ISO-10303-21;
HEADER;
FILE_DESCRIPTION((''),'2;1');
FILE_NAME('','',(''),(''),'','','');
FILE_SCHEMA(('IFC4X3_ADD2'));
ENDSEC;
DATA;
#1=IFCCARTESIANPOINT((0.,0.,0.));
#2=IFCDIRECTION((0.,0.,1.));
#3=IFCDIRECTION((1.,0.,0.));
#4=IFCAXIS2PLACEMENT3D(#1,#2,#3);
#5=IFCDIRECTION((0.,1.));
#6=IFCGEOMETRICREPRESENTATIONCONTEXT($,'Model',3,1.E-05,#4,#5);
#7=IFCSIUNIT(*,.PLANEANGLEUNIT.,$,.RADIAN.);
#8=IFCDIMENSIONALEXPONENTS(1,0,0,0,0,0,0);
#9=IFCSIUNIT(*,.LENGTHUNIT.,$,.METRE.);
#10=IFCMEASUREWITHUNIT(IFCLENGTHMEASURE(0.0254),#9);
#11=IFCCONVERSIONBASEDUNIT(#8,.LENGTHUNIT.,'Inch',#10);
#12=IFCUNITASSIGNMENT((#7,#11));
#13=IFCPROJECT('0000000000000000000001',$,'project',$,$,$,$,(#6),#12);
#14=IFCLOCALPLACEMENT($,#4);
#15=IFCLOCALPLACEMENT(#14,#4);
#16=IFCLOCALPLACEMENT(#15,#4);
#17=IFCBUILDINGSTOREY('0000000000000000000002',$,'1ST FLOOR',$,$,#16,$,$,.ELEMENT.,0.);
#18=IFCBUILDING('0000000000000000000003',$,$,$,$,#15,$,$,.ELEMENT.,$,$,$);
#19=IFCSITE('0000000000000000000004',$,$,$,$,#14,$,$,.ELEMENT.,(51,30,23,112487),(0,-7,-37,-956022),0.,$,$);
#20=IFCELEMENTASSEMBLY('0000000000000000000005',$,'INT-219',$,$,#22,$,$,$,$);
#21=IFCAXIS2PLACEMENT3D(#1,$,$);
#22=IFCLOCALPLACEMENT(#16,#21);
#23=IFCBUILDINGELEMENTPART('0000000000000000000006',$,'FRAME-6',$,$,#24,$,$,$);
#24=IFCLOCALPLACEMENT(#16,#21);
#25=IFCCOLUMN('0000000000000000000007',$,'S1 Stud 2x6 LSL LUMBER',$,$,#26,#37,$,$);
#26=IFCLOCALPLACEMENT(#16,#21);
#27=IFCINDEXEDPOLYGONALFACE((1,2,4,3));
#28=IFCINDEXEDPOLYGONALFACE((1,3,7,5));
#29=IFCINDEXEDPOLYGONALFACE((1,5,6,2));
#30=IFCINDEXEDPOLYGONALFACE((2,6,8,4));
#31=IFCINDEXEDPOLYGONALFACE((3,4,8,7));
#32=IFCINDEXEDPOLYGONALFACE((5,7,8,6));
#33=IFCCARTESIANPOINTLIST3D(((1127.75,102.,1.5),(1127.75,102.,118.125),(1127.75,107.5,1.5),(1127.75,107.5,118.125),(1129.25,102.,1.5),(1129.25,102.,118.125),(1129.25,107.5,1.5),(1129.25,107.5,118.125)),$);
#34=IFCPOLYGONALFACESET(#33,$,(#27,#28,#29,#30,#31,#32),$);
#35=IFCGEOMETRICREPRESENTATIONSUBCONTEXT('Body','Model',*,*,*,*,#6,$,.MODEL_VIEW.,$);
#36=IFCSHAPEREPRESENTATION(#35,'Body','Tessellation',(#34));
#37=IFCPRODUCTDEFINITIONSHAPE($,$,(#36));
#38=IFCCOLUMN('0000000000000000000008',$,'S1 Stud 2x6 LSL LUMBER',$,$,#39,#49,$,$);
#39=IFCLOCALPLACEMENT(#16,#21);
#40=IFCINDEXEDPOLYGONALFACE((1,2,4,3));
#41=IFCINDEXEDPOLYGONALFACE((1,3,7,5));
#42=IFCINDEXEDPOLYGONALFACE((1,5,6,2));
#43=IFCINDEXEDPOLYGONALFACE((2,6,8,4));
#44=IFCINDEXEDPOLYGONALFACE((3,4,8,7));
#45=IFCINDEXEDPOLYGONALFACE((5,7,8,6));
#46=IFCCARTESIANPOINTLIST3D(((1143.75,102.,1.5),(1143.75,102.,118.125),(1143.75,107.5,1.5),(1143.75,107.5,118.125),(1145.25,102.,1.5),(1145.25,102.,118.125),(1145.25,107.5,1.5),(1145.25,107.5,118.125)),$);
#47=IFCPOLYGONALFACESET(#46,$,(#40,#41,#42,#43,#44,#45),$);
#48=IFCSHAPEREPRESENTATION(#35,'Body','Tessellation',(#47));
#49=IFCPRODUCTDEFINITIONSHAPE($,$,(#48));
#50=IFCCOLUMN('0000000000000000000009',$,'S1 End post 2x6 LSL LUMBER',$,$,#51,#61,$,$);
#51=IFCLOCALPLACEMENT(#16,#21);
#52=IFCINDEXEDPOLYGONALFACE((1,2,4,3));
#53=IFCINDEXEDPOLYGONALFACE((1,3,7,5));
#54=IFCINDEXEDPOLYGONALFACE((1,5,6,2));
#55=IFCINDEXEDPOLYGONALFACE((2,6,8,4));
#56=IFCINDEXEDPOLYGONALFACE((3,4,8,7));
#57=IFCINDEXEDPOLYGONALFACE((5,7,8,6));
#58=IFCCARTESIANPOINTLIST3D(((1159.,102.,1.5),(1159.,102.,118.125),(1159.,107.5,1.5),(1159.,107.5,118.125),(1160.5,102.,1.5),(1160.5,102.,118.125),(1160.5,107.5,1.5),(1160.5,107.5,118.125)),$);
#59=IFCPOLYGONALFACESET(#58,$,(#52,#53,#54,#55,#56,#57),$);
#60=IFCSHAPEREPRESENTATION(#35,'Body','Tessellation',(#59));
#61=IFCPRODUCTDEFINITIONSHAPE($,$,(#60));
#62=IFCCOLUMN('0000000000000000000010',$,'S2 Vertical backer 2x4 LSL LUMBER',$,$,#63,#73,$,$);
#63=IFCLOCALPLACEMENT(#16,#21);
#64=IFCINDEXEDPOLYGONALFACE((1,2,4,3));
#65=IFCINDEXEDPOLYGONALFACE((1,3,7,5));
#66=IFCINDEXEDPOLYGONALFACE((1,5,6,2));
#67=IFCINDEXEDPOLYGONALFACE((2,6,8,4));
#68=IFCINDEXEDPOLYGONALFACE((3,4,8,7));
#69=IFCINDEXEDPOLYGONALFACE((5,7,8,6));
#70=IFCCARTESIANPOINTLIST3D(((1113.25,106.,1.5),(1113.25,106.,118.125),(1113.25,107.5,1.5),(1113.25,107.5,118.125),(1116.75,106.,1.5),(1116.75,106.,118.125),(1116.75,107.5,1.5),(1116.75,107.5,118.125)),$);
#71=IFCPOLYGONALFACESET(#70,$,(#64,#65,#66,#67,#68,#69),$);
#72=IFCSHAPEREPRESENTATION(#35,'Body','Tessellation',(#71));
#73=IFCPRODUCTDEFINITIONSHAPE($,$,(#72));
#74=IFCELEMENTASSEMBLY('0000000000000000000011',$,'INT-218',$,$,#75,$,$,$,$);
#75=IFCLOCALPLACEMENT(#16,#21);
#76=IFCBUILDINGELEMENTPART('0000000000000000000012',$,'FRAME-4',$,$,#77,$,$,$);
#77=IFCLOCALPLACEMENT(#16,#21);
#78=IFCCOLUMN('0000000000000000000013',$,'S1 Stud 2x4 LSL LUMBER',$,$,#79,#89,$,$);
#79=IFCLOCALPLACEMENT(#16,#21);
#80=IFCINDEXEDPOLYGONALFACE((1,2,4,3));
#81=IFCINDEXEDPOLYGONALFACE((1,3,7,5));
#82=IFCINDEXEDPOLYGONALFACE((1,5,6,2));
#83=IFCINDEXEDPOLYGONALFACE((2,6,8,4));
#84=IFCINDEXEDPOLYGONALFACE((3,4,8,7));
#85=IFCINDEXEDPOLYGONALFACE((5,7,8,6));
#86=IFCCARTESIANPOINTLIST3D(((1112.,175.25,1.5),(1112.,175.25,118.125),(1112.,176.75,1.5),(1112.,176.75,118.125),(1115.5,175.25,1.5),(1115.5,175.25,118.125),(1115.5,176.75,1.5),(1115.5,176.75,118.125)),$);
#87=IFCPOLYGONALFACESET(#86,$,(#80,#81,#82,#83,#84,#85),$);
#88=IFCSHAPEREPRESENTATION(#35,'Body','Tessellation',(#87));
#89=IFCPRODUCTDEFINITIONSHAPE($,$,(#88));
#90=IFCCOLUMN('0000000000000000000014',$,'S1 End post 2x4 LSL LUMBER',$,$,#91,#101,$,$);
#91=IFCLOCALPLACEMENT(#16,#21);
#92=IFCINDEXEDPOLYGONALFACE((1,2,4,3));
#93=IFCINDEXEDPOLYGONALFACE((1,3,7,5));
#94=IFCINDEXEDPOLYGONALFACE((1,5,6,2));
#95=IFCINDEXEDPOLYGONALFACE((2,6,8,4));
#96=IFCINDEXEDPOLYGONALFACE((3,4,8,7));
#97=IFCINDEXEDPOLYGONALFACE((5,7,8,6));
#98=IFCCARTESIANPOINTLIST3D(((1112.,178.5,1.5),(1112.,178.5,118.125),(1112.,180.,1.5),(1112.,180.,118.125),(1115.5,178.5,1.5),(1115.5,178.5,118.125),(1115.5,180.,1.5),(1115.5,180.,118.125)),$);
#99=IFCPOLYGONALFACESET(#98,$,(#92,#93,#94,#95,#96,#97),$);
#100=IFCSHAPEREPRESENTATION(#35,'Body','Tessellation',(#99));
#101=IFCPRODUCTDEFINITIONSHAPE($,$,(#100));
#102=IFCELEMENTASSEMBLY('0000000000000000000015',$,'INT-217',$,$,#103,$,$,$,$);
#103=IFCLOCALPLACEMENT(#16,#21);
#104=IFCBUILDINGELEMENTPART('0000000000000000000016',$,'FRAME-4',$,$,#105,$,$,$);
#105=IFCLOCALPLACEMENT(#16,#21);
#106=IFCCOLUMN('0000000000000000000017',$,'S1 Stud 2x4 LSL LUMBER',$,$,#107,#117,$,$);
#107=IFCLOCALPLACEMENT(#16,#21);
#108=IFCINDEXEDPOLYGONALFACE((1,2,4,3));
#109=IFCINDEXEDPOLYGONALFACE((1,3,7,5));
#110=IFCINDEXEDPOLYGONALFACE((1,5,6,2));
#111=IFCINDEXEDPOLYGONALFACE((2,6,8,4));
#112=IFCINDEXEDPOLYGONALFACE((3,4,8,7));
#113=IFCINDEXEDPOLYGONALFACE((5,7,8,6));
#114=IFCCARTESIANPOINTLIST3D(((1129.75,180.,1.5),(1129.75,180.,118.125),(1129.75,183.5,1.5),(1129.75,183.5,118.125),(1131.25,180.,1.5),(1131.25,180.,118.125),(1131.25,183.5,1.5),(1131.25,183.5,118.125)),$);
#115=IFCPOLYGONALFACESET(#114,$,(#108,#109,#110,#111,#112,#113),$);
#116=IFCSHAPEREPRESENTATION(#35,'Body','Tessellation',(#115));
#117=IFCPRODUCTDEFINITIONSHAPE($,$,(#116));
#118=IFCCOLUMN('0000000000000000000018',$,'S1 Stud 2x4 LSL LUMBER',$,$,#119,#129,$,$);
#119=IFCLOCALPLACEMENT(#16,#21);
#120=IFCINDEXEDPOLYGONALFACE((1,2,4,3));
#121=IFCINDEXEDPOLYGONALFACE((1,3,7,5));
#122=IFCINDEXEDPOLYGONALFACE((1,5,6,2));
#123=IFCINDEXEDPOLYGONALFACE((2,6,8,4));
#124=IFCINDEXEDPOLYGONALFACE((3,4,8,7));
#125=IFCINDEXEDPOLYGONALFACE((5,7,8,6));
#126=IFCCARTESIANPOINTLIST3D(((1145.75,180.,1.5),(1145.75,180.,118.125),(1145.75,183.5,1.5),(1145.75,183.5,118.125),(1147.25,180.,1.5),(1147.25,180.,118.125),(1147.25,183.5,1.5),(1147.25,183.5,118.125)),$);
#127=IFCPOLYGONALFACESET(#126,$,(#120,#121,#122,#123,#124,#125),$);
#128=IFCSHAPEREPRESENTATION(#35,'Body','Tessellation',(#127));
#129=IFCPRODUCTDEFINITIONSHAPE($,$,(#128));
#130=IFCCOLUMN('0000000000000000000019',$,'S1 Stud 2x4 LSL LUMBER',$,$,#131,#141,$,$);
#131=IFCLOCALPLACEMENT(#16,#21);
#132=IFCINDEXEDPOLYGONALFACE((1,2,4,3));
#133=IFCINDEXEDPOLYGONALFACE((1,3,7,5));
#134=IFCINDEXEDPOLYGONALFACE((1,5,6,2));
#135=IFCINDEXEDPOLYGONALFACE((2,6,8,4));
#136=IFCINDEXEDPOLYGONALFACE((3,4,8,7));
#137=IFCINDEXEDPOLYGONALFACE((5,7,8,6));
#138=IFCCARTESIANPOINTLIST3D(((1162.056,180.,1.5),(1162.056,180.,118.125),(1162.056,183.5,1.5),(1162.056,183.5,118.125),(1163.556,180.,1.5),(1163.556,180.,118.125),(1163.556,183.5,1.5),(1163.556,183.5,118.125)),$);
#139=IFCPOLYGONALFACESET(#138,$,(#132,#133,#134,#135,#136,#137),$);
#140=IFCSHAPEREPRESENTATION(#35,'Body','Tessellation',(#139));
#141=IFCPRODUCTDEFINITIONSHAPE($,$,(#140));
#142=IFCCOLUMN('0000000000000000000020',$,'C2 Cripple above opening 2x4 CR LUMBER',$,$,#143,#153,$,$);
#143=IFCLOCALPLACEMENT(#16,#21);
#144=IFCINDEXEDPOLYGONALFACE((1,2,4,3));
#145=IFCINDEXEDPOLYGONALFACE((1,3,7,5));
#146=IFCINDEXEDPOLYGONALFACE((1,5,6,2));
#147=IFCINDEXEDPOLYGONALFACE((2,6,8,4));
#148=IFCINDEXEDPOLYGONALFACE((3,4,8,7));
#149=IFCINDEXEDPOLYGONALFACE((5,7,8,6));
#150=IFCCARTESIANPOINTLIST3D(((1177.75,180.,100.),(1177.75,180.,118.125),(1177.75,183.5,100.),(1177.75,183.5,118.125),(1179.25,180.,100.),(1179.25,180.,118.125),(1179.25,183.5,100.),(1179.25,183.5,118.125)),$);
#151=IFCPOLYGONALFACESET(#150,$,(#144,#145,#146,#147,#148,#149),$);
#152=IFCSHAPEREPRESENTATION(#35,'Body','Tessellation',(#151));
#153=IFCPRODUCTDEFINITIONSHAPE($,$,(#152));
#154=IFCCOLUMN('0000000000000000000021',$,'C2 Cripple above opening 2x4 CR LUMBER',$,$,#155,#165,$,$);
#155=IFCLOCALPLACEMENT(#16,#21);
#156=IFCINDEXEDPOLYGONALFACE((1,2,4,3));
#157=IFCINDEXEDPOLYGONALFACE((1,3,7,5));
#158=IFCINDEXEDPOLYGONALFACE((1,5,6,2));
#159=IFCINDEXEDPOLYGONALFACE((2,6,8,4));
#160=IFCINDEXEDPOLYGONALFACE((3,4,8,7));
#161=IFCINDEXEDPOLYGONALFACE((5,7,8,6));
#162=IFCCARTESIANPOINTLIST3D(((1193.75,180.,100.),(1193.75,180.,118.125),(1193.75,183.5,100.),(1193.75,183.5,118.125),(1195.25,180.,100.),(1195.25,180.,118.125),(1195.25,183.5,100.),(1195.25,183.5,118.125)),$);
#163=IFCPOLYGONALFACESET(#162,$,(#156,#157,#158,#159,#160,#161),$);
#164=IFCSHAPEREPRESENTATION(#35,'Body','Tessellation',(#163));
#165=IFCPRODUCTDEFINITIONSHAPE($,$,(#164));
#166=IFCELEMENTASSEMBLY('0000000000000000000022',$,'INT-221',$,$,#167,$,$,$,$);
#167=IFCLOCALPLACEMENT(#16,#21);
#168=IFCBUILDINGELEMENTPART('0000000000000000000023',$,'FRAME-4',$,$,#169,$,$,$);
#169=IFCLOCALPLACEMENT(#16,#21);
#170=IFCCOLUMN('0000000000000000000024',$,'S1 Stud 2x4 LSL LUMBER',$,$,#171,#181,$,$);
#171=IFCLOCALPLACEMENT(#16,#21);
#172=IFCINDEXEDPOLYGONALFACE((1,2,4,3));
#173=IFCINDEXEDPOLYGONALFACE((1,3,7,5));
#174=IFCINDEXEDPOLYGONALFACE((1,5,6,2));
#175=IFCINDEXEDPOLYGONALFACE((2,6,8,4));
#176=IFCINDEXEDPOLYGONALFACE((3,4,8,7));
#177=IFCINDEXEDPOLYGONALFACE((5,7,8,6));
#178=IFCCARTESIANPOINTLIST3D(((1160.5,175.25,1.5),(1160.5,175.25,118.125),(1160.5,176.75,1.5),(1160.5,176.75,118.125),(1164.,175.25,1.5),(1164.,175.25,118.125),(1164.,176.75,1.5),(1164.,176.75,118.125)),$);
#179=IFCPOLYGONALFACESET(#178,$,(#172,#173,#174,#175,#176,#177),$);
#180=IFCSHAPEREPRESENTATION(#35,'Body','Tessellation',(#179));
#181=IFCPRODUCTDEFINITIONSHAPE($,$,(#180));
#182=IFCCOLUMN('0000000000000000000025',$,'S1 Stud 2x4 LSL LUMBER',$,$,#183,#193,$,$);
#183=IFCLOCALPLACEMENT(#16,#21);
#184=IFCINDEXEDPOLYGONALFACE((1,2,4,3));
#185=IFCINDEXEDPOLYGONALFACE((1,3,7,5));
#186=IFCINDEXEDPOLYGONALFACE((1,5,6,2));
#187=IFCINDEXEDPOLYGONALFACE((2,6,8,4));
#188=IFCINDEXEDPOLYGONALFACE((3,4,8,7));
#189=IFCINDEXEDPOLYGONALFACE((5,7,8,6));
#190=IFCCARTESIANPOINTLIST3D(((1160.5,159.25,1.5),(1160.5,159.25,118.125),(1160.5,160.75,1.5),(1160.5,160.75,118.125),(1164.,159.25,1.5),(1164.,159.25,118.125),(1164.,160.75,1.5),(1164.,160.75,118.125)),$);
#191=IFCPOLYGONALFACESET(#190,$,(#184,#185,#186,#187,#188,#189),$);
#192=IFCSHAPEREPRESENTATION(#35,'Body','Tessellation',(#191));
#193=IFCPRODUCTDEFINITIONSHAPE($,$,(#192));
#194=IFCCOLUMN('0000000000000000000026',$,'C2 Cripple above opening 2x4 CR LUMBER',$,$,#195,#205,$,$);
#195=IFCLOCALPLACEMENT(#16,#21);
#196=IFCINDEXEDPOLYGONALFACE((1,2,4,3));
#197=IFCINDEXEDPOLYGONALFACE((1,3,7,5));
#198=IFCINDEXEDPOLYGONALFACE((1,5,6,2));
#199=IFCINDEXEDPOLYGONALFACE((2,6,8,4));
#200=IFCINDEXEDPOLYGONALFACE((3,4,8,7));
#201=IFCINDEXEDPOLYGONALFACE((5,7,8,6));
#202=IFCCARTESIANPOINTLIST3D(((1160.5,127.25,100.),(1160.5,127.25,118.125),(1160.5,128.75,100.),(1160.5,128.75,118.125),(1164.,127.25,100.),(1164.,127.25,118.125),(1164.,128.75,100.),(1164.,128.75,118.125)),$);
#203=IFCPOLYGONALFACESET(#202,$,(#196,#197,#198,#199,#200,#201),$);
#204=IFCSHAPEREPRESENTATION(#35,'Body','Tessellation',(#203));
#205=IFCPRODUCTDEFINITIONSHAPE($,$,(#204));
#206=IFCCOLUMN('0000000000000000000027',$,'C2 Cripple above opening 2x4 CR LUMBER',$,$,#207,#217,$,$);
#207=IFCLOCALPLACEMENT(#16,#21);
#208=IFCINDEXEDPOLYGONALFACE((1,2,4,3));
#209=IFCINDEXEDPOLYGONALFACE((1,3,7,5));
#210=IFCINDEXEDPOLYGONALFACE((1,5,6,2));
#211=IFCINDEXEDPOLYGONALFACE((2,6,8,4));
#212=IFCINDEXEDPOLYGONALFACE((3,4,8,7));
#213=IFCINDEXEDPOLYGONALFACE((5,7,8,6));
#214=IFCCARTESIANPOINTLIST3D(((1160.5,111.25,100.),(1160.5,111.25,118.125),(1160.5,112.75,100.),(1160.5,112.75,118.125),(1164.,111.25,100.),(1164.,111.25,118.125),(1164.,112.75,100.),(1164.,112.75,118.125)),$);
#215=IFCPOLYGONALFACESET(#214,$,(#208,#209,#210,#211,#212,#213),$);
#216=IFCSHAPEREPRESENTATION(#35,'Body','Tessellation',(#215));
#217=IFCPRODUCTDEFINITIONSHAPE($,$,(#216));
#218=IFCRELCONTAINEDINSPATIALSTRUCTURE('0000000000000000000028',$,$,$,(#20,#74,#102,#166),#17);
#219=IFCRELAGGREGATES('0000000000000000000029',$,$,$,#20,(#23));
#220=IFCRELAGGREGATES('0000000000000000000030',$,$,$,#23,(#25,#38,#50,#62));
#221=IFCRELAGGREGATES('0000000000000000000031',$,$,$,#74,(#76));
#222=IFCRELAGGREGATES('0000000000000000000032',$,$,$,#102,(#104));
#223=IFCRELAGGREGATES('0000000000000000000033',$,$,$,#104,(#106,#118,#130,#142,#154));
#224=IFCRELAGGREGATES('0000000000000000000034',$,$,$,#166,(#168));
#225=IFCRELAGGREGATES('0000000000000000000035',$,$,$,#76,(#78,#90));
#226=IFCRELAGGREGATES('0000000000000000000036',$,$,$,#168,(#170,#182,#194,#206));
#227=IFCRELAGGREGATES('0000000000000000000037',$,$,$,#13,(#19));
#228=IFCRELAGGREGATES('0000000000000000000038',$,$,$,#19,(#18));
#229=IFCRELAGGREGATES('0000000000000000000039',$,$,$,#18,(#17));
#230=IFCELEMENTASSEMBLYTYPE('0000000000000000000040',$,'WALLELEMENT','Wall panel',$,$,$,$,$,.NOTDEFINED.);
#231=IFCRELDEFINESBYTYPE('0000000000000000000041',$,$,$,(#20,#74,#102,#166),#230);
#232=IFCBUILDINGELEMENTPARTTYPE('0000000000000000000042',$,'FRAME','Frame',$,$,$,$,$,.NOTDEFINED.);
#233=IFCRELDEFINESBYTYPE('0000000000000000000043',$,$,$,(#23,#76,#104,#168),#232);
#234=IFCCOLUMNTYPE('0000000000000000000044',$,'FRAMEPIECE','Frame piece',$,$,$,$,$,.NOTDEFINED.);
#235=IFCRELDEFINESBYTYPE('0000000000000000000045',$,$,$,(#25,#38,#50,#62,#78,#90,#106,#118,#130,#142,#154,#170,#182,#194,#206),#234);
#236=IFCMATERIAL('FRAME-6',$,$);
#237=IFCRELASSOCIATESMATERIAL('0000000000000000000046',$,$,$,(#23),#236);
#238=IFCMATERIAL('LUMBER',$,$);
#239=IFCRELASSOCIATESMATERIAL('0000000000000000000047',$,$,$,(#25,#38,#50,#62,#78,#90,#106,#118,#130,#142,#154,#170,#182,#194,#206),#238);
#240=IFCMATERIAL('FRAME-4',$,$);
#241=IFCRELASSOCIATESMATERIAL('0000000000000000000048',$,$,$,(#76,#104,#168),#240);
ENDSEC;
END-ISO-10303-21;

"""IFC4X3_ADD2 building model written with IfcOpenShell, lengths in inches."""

from ifc_helpers import new_model, entity, si_unit, converted_unit, direction, frame, origin_with_axes, origin_2d_with_axis, place, context, subcontext, project, spatial, rectangle, extrude, material, type_object, element, aggregate, save


model = new_model("IFC4X3_ADD2")

# Units and contexts
model_context = context("Model", 3, precision=1e-05, world=origin_with_axes(), true_north=direction((0.0, 1.0)))
body_context = subcontext(model_context, "Body", "Model", "MODEL_VIEW")
ifc_project = project(units=[si_unit("PLANEANGLEUNIT", "RADIAN"), converted_unit("LENGTHUNIT", "Inch", entity("IfcLengthMeasure", 0.0254), si_unit("LENGTHUNIT", "METRE"), dimensions=[1, 0, 0, 0, 0, 0, 0])], contexts=[model_context])

# Site, building, storey
site_placement = place(None, origin_with_axes())
site = spatial("IfcSite", under=ifc_project, at=site_placement, CompositionType="ELEMENT", RefLatitude=(51, 30, 23, 112487), RefLongitude=(0, -7, -37, -956022), RefElevation=0.0)
building_placement = place(site_placement, origin_with_axes())
building = spatial("IfcBuilding", under=site, at=building_placement, CompositionType="ELEMENT")
storey_placement = place(building_placement, origin_with_axes())
storey = spatial("IfcBuildingStorey", under=building, at=storey_placement, Name="1ST FLOOR", CompositionType="ELEMENT", Elevation=0.0)

# Element assemblies, building element parts, columns
element_assembly_type = type_object("IfcElementAssemblyType", Name="WALLELEMENT", Description="Wall panel", PredefinedType="NOTDEFINED")
assembly_1_placement = place(storey_placement, origin_with_axes())
assembly_1 = element("IfcElementAssembly", 1, at=assembly_1_placement, inside=storey, type_object=element_assembly_type, Name="INT-219")
ifc_material_1 = material(Name="FRAME-6")
building_element_part_type = type_object("IfcBuildingElementPartType", Name="FRAME", Description="Frame", PredefinedType="NOTDEFINED")
building_element_part_1_placement = place(storey_placement, origin_with_axes())
building_element_part_1 = element("IfcBuildingElementPart", 2, at=building_element_part_1_placement, type_object=building_element_part_type, material=ifc_material_1, Name="FRAME-6")
aggregate(assembly_1, [building_element_part_1])
ifc_material_2 = material(Name="LUMBER")
column_type = type_object("IfcColumnType", Name="FRAMEPIECE", Description="Frame piece", PredefinedType="NOTDEFINED")
column_1_placement = place(storey_placement, frame((1128.5, 104.75, 118.125), z_axis=(0.0, 0.0, -1.0), x_axis=(-1.0, 0.0, 0.0)))
column_1 = element("IfcColumn", 3, at=column_1_placement, type_object=column_type, material=ifc_material_2, Name="S1 Stud 2x6 LSL LUMBER", context=body_context, shape_type="SweptSolid", body=[
    extrude(rectangle(XDim=1.5, YDim=5.5, at=origin_2d_with_axis()), origin_with_axes(), (0.0, 0.0, 1.0), 116.625),
])
column_2_placement = place(storey_placement, frame((1144.5, 104.75, 118.125), z_axis=(0.0, 0.0, -1.0), x_axis=(-1.0, 0.0, 0.0)))
column_2 = element("IfcColumn", 4, at=column_2_placement, type_object=column_type, material=ifc_material_2, Name="S1 Stud 2x6 LSL LUMBER", context=body_context, shape_type="SweptSolid", body=[
    extrude(rectangle(XDim=1.5, YDim=5.5, at=origin_2d_with_axis()), origin_with_axes(), (0.0, 0.0, 1.0), 116.625),
])
column_3_placement = place(storey_placement, frame((1159.75, 104.75, 118.125), z_axis=(0.0, 0.0, -1.0), x_axis=(-1.0, 0.0, 0.0)))
column_3 = element("IfcColumn", 5, at=column_3_placement, type_object=column_type, material=ifc_material_2, Name="S1 End post 2x6 LSL LUMBER", context=body_context, shape_type="SweptSolid", body=[
    extrude(rectangle(XDim=1.5, YDim=5.5, at=origin_2d_with_axis()), origin_with_axes(), (0.0, 0.0, 1.0), 116.625),
])
column_4_placement = place(storey_placement, frame((1115.0, 106.75, 118.125), z_axis=(0.0, 0.0, -1.0), x_axis=(0.0, -1.0, 0.0)))
column_4 = element("IfcColumn", 6, at=column_4_placement, type_object=column_type, material=ifc_material_2, Name="S2 Vertical backer 2x4 LSL LUMBER", context=body_context, shape_type="SweptSolid", body=[
    extrude(rectangle(XDim=1.5, YDim=3.5, at=origin_2d_with_axis()), origin_with_axes(), (0.0, 0.0, 1.0), 116.625),
])
aggregate(building_element_part_1, [column_1, column_2, column_3, column_4])
assembly_2_placement = place(storey_placement, origin_with_axes())
assembly_2 = element("IfcElementAssembly", 7, at=assembly_2_placement, inside=storey, type_object=element_assembly_type, Name="INT-218")
ifc_material_3 = material(Name="FRAME-4")
building_element_part_2_placement = place(storey_placement, origin_with_axes())
building_element_part_2 = element("IfcBuildingElementPart", 8, at=building_element_part_2_placement, type_object=building_element_part_type, material=ifc_material_3, Name="FRAME-4")
aggregate(assembly_2, [building_element_part_2])
column_5_placement = place(storey_placement, frame((1113.75, 176.0, 118.125), z_axis=(0.0, 0.0, -1.0), x_axis=(0.0, -1.0, 0.0)))
column_5 = element("IfcColumn", 9, at=column_5_placement, type_object=column_type, material=ifc_material_2, Name="S1 Stud 2x4 LSL LUMBER", context=body_context, shape_type="SweptSolid", body=[
    extrude(rectangle(XDim=1.5, YDim=3.5, at=origin_2d_with_axis()), origin_with_axes(), (0.0, 0.0, 1.0), 116.625),
])
column_6_placement = place(storey_placement, frame((1113.75, 179.25, 118.125), z_axis=(0.0, 0.0, -1.0), x_axis=(0.0, -1.0, 0.0)))
column_6 = element("IfcColumn", 10, at=column_6_placement, type_object=column_type, material=ifc_material_2, Name="S1 End post 2x4 LSL LUMBER", context=body_context, shape_type="SweptSolid", body=[
    extrude(rectangle(XDim=1.5, YDim=3.5, at=origin_2d_with_axis()), origin_with_axes(), (0.0, 0.0, 1.0), 116.625),
])
assembly_3_placement = place(storey_placement, origin_with_axes())
assembly_3 = element("IfcElementAssembly", 11, at=assembly_3_placement, inside=storey, type_object=element_assembly_type, Name="INT-217")
building_element_part_3_placement = place(storey_placement, origin_with_axes())
building_element_part_3 = element("IfcBuildingElementPart", 12, at=building_element_part_3_placement, type_object=building_element_part_type, material=ifc_material_3, Name="FRAME-4")
aggregate(assembly_3, [building_element_part_3])
column_7_placement = place(storey_placement, frame((1130.5, 181.75, 118.125), z_axis=(0.0, 0.0, -1.0), x_axis=(-1.0, 0.0, 0.0)))
column_7 = element("IfcColumn", 13, at=column_7_placement, type_object=column_type, material=ifc_material_2, Name="S1 Stud 2x4 LSL LUMBER", context=body_context, shape_type="SweptSolid", body=[
    extrude(rectangle(XDim=1.5, YDim=3.5, at=origin_2d_with_axis()), origin_with_axes(), (0.0, 0.0, 1.0), 116.625),
])
column_8_placement = place(storey_placement, frame((1146.5, 181.75, 118.125), z_axis=(0.0, 0.0, -1.0), x_axis=(-1.0, 0.0, 0.0)))
column_8 = element("IfcColumn", 14, at=column_8_placement, type_object=column_type, material=ifc_material_2, Name="S1 Stud 2x4 LSL LUMBER", context=body_context, shape_type="SweptSolid", body=[
    extrude(rectangle(XDim=1.5, YDim=3.5, at=origin_2d_with_axis()), origin_with_axes(), (0.0, 0.0, 1.0), 116.625),
])
column_9_placement = place(storey_placement, frame((1162.806, 181.75, 118.125), z_axis=(0.0, 0.0, -1.0), x_axis=(-1.0, 0.0, 0.0)))
column_9 = element("IfcColumn", 15, at=column_9_placement, type_object=column_type, material=ifc_material_2, Name="S1 Stud 2x4 LSL LUMBER", context=body_context, shape_type="SweptSolid", body=[
    extrude(rectangle(XDim=1.5, YDim=3.5, at=origin_2d_with_axis()), origin_with_axes(), (0.0, 0.0, 1.0), 116.625),
])
column_10_placement = place(storey_placement, frame((1178.5, 181.75, 118.125), z_axis=(0.0, 0.0, -1.0), x_axis=(-1.0, 0.0, 0.0)))
column_10 = element("IfcColumn", 16, at=column_10_placement, type_object=column_type, material=ifc_material_2, Name="C2 Cripple above opening 2x4 CR LUMBER", context=body_context, shape_type="SweptSolid", body=[
    extrude(rectangle(XDim=1.5, YDim=3.5, at=origin_2d_with_axis()), origin_with_axes(), (0.0, 0.0, 1.0), 18.125),
])
column_11_placement = place(storey_placement, frame((1194.5, 181.75, 118.125), z_axis=(0.0, 0.0, -1.0), x_axis=(-1.0, 0.0, 0.0)))
column_11 = element("IfcColumn", 17, at=column_11_placement, type_object=column_type, material=ifc_material_2, Name="C2 Cripple above opening 2x4 CR LUMBER", context=body_context, shape_type="SweptSolid", body=[
    extrude(rectangle(XDim=1.5, YDim=3.5, at=origin_2d_with_axis()), origin_with_axes(), (0.0, 0.0, 1.0), 18.125),
])
aggregate(building_element_part_3, [column_7, column_8, column_9, column_10, column_11])
assembly_4_placement = place(storey_placement, origin_with_axes())
assembly_4 = element("IfcElementAssembly", 18, at=assembly_4_placement, inside=storey, type_object=element_assembly_type, Name="INT-221")
building_element_part_4_placement = place(storey_placement, origin_with_axes())
building_element_part_4 = element("IfcBuildingElementPart", 19, at=building_element_part_4_placement, type_object=building_element_part_type, material=ifc_material_3, Name="FRAME-4")
aggregate(assembly_4, [building_element_part_4])
column_12_placement = place(storey_placement, frame((1162.25, 176.0, 118.125), z_axis=(0.0, 0.0, -1.0), x_axis=(0.0, 1.0, 0.0)))
column_12 = element("IfcColumn", 20, at=column_12_placement, type_object=column_type, material=ifc_material_2, Name="S1 Stud 2x4 LSL LUMBER", context=body_context, shape_type="SweptSolid", body=[
    extrude(rectangle(XDim=1.5, YDim=3.5, at=origin_2d_with_axis()), origin_with_axes(), (0.0, 0.0, 1.0), 116.625),
])
column_13_placement = place(storey_placement, frame((1162.25, 160.0, 118.125), z_axis=(0.0, 0.0, -1.0), x_axis=(0.0, 1.0, 0.0)))
column_13 = element("IfcColumn", 21, at=column_13_placement, type_object=column_type, material=ifc_material_2, Name="S1 Stud 2x4 LSL LUMBER", context=body_context, shape_type="SweptSolid", body=[
    extrude(rectangle(XDim=1.5, YDim=3.5, at=origin_2d_with_axis()), origin_with_axes(), (0.0, 0.0, 1.0), 116.625),
])
column_14_placement = place(storey_placement, frame((1162.25, 128.0, 118.125), z_axis=(0.0, 0.0, -1.0), x_axis=(0.0, 1.0, 0.0)))
column_14 = element("IfcColumn", 22, at=column_14_placement, type_object=column_type, material=ifc_material_2, Name="C2 Cripple above opening 2x4 CR LUMBER", context=body_context, shape_type="SweptSolid", body=[
    extrude(rectangle(XDim=1.5, YDim=3.5, at=origin_2d_with_axis()), origin_with_axes(), (0.0, 0.0, 1.0), 18.125),
])
column_15_placement = place(storey_placement, frame((1162.25, 112.0, 118.125), z_axis=(0.0, 0.0, -1.0), x_axis=(0.0, 1.0, 0.0)))
column_15 = element("IfcColumn", 23, at=column_15_placement, type_object=column_type, material=ifc_material_2, Name="C2 Cripple above opening 2x4 CR LUMBER", context=body_context, shape_type="SweptSolid", body=[
    extrude(rectangle(XDim=1.5, YDim=3.5, at=origin_2d_with_axis()), origin_with_axes(), (0.0, 0.0, 1.0), 18.125),
])

aggregate(building_element_part_2, [column_5, column_6])
aggregate(building_element_part_4, [column_12, column_13, column_14, column_15])

save(model, "model.ifc")
